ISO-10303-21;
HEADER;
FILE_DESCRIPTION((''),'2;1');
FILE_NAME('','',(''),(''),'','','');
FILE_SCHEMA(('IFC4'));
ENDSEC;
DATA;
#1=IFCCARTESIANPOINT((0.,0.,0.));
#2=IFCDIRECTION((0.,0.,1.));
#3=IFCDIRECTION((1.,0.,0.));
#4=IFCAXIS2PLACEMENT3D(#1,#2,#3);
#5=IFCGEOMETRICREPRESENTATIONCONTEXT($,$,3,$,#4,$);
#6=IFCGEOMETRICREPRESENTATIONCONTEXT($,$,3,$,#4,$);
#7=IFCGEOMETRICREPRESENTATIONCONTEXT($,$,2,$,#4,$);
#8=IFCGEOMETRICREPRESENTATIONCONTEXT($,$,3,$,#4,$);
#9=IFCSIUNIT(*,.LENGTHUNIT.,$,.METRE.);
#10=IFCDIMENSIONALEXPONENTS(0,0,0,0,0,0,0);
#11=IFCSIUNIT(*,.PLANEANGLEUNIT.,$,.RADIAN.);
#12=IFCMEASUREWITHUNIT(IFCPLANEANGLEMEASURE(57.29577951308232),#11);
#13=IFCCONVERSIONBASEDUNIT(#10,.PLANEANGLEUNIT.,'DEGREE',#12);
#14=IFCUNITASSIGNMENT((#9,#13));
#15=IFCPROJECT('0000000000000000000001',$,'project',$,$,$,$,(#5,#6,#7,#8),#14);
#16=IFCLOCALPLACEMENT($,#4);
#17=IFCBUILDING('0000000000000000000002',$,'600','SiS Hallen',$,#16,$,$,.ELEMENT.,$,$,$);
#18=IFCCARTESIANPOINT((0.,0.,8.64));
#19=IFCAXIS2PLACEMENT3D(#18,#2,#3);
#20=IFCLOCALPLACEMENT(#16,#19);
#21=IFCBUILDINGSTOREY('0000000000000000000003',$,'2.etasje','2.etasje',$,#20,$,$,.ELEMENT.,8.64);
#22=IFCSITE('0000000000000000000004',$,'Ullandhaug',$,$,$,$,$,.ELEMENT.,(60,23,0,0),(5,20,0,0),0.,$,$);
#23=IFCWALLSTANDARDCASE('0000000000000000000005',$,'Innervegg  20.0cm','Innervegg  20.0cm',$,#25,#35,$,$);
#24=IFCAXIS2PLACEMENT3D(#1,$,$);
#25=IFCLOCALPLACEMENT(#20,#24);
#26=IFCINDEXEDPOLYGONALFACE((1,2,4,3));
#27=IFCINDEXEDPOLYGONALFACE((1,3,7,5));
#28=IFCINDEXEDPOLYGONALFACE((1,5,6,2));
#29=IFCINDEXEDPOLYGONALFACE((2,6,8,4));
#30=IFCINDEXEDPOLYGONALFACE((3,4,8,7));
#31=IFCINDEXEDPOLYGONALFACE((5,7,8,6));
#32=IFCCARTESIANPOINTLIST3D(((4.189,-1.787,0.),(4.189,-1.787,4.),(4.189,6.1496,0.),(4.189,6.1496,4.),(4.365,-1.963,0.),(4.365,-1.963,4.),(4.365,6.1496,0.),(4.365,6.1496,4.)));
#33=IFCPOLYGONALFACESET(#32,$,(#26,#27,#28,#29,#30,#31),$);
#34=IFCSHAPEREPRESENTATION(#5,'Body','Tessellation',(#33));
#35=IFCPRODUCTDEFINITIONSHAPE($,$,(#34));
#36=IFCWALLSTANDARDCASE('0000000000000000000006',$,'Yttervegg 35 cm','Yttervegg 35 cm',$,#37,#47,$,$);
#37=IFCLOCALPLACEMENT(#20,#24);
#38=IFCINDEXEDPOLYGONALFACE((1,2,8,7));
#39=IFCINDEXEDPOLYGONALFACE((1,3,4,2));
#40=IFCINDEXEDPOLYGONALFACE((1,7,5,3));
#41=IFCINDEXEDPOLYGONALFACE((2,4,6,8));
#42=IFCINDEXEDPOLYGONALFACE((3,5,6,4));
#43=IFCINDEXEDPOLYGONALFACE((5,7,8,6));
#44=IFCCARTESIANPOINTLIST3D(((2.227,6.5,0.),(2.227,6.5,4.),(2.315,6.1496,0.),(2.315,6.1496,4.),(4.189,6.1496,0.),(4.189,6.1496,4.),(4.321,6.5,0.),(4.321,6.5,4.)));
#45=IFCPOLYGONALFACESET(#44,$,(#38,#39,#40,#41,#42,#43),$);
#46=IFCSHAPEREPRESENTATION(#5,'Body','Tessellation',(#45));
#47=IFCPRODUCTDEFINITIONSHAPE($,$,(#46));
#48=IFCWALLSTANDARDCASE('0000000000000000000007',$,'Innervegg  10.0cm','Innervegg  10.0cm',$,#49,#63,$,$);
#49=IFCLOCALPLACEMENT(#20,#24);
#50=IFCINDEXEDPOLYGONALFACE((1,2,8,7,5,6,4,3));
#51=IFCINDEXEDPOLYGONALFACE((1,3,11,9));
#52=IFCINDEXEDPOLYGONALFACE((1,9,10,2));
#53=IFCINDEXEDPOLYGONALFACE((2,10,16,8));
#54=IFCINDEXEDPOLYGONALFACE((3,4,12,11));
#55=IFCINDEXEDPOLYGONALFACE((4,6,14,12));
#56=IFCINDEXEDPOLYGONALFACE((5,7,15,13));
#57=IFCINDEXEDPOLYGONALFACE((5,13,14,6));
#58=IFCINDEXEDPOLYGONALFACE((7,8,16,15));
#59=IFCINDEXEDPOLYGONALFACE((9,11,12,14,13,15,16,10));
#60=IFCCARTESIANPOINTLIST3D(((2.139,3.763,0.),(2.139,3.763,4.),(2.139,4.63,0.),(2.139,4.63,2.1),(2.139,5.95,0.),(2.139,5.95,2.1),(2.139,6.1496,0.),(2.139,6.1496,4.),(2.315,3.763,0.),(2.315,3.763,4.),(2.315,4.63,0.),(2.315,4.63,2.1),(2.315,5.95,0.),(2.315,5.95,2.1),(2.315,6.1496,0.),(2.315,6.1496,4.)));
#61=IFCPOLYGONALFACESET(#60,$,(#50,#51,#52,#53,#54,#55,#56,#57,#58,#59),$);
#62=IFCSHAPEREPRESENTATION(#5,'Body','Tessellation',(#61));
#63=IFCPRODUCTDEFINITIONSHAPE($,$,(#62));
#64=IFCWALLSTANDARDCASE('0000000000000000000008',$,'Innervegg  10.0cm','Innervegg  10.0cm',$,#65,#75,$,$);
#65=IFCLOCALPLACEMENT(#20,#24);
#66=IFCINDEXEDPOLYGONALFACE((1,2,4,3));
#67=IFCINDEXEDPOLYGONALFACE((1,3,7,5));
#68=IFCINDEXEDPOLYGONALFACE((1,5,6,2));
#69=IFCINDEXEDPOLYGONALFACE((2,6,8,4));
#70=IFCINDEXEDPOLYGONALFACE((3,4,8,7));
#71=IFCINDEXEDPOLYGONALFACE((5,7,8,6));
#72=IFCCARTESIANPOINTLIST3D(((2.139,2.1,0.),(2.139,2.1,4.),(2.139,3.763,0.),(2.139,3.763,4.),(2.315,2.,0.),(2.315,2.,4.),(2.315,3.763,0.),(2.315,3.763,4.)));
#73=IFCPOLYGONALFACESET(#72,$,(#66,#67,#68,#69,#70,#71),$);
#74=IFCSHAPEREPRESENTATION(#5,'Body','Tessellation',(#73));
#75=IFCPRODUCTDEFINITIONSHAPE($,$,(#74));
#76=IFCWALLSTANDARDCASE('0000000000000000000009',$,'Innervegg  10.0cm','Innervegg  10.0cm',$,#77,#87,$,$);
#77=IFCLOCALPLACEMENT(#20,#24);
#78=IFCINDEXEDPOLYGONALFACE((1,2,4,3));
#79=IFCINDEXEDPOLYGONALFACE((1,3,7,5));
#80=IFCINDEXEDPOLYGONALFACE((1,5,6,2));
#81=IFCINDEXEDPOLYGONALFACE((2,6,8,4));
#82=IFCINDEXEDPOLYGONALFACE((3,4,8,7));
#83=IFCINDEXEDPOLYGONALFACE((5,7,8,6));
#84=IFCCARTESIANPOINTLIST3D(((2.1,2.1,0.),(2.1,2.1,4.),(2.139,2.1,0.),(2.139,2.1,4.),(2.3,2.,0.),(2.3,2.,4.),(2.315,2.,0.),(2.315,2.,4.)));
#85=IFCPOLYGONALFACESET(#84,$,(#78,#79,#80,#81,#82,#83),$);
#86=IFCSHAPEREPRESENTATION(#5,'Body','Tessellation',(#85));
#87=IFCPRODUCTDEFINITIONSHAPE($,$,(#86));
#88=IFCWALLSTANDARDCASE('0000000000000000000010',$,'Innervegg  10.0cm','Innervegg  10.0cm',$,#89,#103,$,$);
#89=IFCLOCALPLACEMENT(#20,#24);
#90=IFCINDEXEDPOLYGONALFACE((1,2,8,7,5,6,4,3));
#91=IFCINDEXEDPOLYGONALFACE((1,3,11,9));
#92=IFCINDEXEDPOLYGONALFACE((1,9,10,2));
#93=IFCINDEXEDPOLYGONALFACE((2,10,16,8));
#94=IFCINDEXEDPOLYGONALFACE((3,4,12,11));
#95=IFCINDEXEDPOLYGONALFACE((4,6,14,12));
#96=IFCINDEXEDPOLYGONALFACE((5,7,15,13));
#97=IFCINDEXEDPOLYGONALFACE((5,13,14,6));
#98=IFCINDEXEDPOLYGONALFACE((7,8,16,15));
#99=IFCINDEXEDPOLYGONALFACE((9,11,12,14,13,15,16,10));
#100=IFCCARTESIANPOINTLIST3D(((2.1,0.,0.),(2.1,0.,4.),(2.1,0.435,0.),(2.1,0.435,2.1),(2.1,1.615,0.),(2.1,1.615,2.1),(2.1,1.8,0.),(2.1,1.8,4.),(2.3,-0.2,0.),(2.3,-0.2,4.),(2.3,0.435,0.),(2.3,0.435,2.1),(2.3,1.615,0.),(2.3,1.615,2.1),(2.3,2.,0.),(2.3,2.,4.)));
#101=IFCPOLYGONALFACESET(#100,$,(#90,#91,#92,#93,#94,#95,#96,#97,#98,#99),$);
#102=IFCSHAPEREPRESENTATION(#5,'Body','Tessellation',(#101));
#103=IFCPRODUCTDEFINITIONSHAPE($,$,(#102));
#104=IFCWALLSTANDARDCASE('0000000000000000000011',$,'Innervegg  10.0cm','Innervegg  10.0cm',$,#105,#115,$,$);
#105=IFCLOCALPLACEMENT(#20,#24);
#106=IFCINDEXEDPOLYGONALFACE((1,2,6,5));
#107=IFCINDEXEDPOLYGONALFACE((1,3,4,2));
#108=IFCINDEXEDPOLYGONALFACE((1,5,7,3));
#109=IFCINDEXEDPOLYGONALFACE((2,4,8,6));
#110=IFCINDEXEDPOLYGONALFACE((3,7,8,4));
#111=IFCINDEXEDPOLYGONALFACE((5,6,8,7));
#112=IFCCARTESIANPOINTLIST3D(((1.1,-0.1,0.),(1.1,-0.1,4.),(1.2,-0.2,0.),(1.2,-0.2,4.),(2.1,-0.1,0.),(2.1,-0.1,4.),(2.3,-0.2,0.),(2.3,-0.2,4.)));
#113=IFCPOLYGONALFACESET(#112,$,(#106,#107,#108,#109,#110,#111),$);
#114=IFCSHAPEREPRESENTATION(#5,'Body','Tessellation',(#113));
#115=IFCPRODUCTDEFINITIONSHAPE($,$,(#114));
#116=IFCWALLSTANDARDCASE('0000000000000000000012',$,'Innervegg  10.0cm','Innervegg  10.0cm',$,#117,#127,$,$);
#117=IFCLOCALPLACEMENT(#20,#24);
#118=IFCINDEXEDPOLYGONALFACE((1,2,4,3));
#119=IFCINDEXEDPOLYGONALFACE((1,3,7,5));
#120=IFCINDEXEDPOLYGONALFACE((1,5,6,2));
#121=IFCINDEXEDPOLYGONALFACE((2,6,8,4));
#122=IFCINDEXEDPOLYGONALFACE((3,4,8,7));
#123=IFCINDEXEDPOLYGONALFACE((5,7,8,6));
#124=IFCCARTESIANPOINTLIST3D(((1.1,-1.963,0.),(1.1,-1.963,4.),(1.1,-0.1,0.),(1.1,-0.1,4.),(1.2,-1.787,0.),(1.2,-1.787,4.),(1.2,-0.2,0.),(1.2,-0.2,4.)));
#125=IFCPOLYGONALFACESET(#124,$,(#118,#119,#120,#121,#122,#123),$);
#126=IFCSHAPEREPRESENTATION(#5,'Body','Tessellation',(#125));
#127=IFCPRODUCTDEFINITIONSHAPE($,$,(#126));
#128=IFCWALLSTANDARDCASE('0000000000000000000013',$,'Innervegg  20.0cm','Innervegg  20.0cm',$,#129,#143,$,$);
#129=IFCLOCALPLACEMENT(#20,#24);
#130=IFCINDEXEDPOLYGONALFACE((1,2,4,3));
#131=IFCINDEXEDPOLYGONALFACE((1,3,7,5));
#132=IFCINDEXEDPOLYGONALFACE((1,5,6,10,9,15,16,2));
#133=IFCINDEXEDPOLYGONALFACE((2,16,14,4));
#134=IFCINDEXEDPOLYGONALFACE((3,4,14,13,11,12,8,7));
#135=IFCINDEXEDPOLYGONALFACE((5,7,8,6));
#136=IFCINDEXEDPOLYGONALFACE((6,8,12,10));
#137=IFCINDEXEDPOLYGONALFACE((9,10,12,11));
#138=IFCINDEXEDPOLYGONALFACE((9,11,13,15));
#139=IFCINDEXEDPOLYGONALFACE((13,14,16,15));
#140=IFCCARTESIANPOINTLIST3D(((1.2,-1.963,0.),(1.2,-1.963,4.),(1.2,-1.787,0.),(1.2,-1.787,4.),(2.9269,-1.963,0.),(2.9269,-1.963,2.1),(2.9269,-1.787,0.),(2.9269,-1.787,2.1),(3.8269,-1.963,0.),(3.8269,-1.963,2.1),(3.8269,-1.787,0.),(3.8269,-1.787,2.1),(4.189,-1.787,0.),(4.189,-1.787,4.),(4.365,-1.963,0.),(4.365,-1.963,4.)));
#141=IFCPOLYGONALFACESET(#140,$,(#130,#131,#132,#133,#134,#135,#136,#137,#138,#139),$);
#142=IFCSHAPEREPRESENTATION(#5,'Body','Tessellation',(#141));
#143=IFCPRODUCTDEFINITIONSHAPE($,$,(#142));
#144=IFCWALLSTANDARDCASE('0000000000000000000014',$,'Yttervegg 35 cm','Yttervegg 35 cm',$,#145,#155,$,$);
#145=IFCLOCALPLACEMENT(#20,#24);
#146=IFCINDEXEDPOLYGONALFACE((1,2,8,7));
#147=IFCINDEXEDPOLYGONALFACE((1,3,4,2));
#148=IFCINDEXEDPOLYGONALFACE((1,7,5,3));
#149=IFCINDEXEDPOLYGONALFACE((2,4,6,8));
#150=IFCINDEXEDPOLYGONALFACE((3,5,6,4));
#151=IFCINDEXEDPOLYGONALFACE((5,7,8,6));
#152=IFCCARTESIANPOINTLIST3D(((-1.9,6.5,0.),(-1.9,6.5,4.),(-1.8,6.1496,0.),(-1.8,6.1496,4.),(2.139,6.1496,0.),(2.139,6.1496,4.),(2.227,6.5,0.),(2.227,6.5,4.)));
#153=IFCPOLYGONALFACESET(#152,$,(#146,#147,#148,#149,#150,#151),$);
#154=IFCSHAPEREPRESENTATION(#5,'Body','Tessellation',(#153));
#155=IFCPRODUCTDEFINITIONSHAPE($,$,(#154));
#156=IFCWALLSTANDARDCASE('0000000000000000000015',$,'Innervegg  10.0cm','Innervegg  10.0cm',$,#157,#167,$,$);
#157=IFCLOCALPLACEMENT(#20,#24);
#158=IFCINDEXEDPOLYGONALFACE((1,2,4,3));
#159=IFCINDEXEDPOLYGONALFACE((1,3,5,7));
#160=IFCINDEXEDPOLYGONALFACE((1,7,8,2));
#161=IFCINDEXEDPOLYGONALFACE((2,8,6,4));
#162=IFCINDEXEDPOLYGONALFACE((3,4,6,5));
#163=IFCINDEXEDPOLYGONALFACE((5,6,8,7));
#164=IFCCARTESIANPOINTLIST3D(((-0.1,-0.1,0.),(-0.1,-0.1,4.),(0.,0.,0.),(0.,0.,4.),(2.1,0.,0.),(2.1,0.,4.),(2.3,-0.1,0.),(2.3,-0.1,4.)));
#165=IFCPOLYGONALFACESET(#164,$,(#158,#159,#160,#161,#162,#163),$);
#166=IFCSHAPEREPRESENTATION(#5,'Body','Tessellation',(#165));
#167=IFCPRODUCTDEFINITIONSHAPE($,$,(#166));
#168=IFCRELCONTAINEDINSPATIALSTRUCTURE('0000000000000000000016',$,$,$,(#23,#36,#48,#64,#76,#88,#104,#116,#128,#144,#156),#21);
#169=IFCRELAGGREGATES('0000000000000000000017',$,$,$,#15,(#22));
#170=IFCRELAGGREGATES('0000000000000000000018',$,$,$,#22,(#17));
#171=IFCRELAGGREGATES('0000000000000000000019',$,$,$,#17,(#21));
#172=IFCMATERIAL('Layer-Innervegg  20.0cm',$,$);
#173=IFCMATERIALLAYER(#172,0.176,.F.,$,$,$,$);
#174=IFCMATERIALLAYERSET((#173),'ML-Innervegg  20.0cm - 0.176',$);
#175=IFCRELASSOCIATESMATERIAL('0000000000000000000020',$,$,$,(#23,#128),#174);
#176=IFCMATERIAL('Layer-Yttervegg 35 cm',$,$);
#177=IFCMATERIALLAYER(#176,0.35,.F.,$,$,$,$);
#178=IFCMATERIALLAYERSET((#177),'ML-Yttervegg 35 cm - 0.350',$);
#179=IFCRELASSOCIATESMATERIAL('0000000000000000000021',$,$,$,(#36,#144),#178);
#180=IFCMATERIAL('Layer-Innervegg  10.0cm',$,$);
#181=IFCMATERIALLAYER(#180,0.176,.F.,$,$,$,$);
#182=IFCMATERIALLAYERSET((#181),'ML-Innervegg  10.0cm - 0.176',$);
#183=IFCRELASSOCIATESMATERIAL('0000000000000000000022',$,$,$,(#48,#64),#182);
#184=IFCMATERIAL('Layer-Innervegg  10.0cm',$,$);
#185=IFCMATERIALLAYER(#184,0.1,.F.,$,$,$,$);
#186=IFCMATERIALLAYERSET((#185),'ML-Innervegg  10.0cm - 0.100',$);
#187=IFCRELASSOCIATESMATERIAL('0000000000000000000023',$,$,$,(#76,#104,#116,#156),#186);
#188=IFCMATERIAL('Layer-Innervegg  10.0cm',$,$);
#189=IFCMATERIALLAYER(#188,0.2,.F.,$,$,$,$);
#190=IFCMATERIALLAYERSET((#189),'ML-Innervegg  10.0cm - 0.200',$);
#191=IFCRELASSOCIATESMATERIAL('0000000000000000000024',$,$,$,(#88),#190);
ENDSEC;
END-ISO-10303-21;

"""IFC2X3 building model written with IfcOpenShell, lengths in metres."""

from ifc_helpers import new_model, entity, si_unit, converted_unit, frame, origin_with_axes, place, context, project, spatial, polyline, outline, extrude, material, layer, layer_set, layer_usage, element, save


model = new_model("IFC2X3")

# Units and contexts
context_of_model_1 = context(None, 3, world=origin_with_axes())
context_of_model_2 = context(None, 3, world=origin_with_axes())
context_of_model_3 = context(None, 2, world=origin_with_axes())
context_of_model_4 = context(None, 3, world=origin_with_axes())
ifc_project = project(units=[si_unit("LENGTHUNIT", "METRE"), converted_unit("PLANEANGLEUNIT", "DEGREE", entity("IfcPlaneAngleMeasure", 57.29577951308232), si_unit("PLANEANGLEUNIT", "RADIAN"), dimensions=[0, 0, 0, 0, 0, 0, 0])], contexts=[context_of_model_1, context_of_model_2, context_of_model_3, context_of_model_4])

# Site, building, storey
site = spatial("IfcSite", under=ifc_project, Name="Ullandhaug", CompositionType="ELEMENT", RefLatitude=(60, 23, 0, 0), RefLongitude=(5, 20, 0, 0), RefElevation=0.0)
building_placement = place(None, origin_with_axes())
building = spatial("IfcBuilding", under=site, at=building_placement, Name="600", Description="SiS Hallen", CompositionType="ELEMENT")
storey_placement = place(building_placement, frame((0.0, 0.0, 8.64), z_axis=(0.0, 0.0, 1.0), x_axis=(1.0, 0.0, 0.0)))
storey = spatial("IfcBuildingStorey", under=building, at=storey_placement, Name="2.etasje", Description="2.etasje", CompositionType="ELEMENT", Elevation=8.64)

# Walls
ifc_material_1 = material(Name="Layer-Yttervegg 35 cm")
ifc_layer_1 = layer(ifc_material_1, 0.35, ventilated=False)
ifc_layer_set_1 = layer_set([ifc_layer_1], Name="ML-Yttervegg 35 cm - 0.350")
ifc_layer_usage_1 = layer_usage(ifc_layer_set_1, "AXIS2", "POSITIVE", 0.0)
ifc_material_2 = material(Name="Layer-Innervegg  20.0cm")
ifc_layer_2 = layer(ifc_material_2, 0.176, ventilated=False)
ifc_layer_set_2 = layer_set([ifc_layer_2], Name="ML-Innervegg  20.0cm - 0.176")
ifc_layer_usage_2 = layer_usage(ifc_layer_set_2, "AXIS2", "POSITIVE", 0.0)
wall_1_placement = place(storey_placement, frame((4.365, -1.963, 0.0), z_axis=(0.0, 0.0, 1.0), x_axis=(0.0, 1.0, 0.0)))
element("IfcWallStandardCase", 1, at=wall_1_placement, inside=storey, material=ifc_layer_usage_2, Name="Innervegg  20.0cm", Description="Innervegg  20.0cm", context=context_of_model_1, shape_type="SweptSolid", body=[
    extrude(outline(polyline([(0.0, 0.0), (8.1126, 0.0), (8.1126, 0.176), (0.176, 0.176), (0.0, 0.0)])), frame((0.0, 0.0, 0.0), z_axis=(0.0, 0.0, 1.0), x_axis=(1.0, 0.0, 0.0)), (0.0, 0.0, 1.0), 4.0),
])
wall_2_placement = place(storey_placement, frame((4.321, 6.5, 0.0), z_axis=(0.0, 0.0, 1.0), x_axis=(-1.0, 0.0, 0.0)))
element("IfcWallStandardCase", 2, at=wall_2_placement, inside=storey, material=ifc_layer_usage_1, Name="Yttervegg 35 cm", Description="Yttervegg 35 cm", context=context_of_model_1, shape_type="SweptSolid", body=[
    extrude(outline(polyline([(0.0, 0.0), (2.094, 0.0), (2.006, 0.3504), (0.132, 0.3504), (0.0, 0.0)])), frame((0.0, 0.0, 0.0), z_axis=(0.0, 0.0, 1.0), x_axis=(1.0, 0.0, 0.0)), (0.0, 0.0, 1.0), 4.0),
])

# Wall, opening
ifc_material_3 = material(Name="Layer-Innervegg  10.0cm")
ifc_layer_3 = layer(ifc_material_3, 0.176, ventilated=False)
ifc_layer_set_3 = layer_set([ifc_layer_3], Name="ML-Innervegg  10.0cm - 0.176")
ifc_layer_usage_3 = layer_usage(ifc_layer_set_3, "AXIS2", "POSITIVE", 0.0)
wall_3_placement = place(storey_placement, frame((2.139, 6.1496, 0.0), z_axis=(0.0, 0.0, 1.0), x_axis=(0.0, -1.0, 0.0)))
wall_3 = element("IfcWallStandardCase", 3, at=wall_3_placement, inside=storey, material=ifc_layer_usage_3, Name="Innervegg  10.0cm", Description="Innervegg  10.0cm", context=context_of_model_1, shape_type="SweptSolid", body=[
    extrude(outline(polyline([(0.0, 0.0), (2.3866, 0.0), (2.3866, 0.176), (0.0, 0.176), (0.0, 0.0)])), frame((0.0, 0.0, 0.0), z_axis=(0.0, 0.0, 1.0), x_axis=(1.0, 0.0, 0.0)), (0.0, 0.0, 1.0), 4.0),
])
opening_1_placement = place(wall_3_placement, frame((0.1996, 0.176, 0.0), z_axis=(0.0, 0.0, 1.0), x_axis=(1.0, 0.0, 0.0)))
element("IfcOpeningElement", 4, at=opening_1_placement, cuts=wall_3, context=context_of_model_1, shape_type="SweptSolid", body=[
    extrude(outline(polyline([(0.0, 0.0), (2.1, 0.0), (2.1, 1.32), (0.0, 1.32), (0.0, 0.0)])), frame((0.0, 0.0, 0.0), z_axis=(0.0, 1.0, 0.0), x_axis=(0.0, 0.0, 1.0)), (0.0, 0.0, -1.0), 0.176),
])

# Walls
wall_4_placement = place(storey_placement, frame((2.139, 3.763, 0.0), z_axis=(0.0, 0.0, 1.0), x_axis=(0.0, -1.0, 0.0)))
element("IfcWallStandardCase", 5, at=wall_4_placement, inside=storey, material=ifc_layer_usage_3, Name="Innervegg  10.0cm", Description="Innervegg  10.0cm", context=context_of_model_1, shape_type="SweptSolid", body=[
    extrude(outline(polyline([(0.0, 0.0), (1.663, 0.0), (1.763, 0.176), (0.0, 0.176), (0.0, 0.0)])), frame((0.0, 0.0, 0.0), z_axis=(0.0, 0.0, 1.0), x_axis=(1.0, 0.0, 0.0)), (0.0, 0.0, 1.0), 4.0),
])
ifc_material_4 = material(Name="Layer-Innervegg  10.0cm")
ifc_layer_4 = layer(ifc_material_4, 0.1, ventilated=False)
ifc_layer_set_4 = layer_set([ifc_layer_4], Name="ML-Innervegg  10.0cm - 0.100")
ifc_layer_usage_4 = layer_usage(ifc_layer_set_4, "AXIS2", "POSITIVE", 0.0)
wall_5_placement = place(storey_placement, frame((2.139, 2.1, 0.0), z_axis=(0.0, 0.0, 1.0), x_axis=(-1.0, 0.0, 0.0)))
element("IfcWallStandardCase", 6, at=wall_5_placement, inside=storey, material=ifc_layer_usage_4, Name="Innervegg  10.0cm", Description="Innervegg  10.0cm", context=context_of_model_1, shape_type="SweptSolid", body=[
    extrude(outline(polyline([(0.0, 0.0), (0.039, 0.0), (-0.161, 0.1), (-0.176, 0.1), (0.0, 0.0)])), frame((0.0, 0.0, 0.0), z_axis=(0.0, 0.0, 1.0), x_axis=(1.0, 0.0, 0.0)), (0.0, 0.0, 1.0), 4.0),
])

# Wall, opening
ifc_material_5 = material(Name="Layer-Innervegg  10.0cm")
ifc_layer_5 = layer(ifc_material_5, 0.2, ventilated=False)
ifc_layer_set_5 = layer_set([ifc_layer_5], Name="ML-Innervegg  10.0cm - 0.200")
ifc_layer_usage_5 = layer_usage(ifc_layer_set_5, "AXIS2", "POSITIVE", 0.0)
wall_6_placement = place(storey_placement, frame((2.1, 1.8, 0.0), z_axis=(0.0, 0.0, 1.0), x_axis=(0.0, -1.0, 0.0)))
wall_6 = element("IfcWallStandardCase", 7, at=wall_6_placement, inside=storey, material=ifc_layer_usage_5, Name="Innervegg  10.0cm", Description="Innervegg  10.0cm", context=context_of_model_1, shape_type="SweptSolid", body=[
    extrude(outline(polyline([(0.0, 0.0), (1.8, 0.0), (2.0, 0.2), (-0.2, 0.2), (0.0, 0.0)])), frame((0.0, 0.0, 0.0), z_axis=(0.0, 0.0, 1.0), x_axis=(1.0, 0.0, 0.0)), (0.0, 0.0, 1.0), 4.0),
])
opening_2_placement = place(wall_6_placement, frame((0.185, 0.2, 0.0), z_axis=(0.0, 0.0, 1.0), x_axis=(1.0, 0.0, 0.0)))
element("IfcOpeningElement", 8, at=opening_2_placement, cuts=wall_6, context=context_of_model_1, shape_type="SweptSolid", body=[
    extrude(outline(polyline([(0.0, 0.0), (2.1, 0.0), (2.1, 1.18), (0.0, 1.18), (0.0, 0.0)])), frame((0.0, 0.0, 0.0), z_axis=(0.0, 1.0, 0.0), x_axis=(0.0, 0.0, 1.0)), (0.0, 0.0, -1.0), 0.2),
])

# Walls
wall_7_placement = place(storey_placement, frame((2.1, -0.1, 0.0), z_axis=(0.0, 0.0, 1.0), x_axis=(-1.0, 0.0, 0.0)))
element("IfcWallStandardCase", 9, at=wall_7_placement, inside=storey, material=ifc_layer_usage_4, Name="Innervegg  10.0cm", Description="Innervegg  10.0cm", context=context_of_model_1, shape_type="SweptSolid", body=[
    extrude(outline(polyline([(0.0, 0.0), (1.0, 0.0), (0.9, 0.1), (-0.2, 0.1), (0.0, 0.0)])), frame((0.0, 0.0, 0.0), z_axis=(0.0, 0.0, 1.0), x_axis=(1.0, 0.0, 0.0)), (0.0, 0.0, 1.0), 4.0),
])
wall_8_placement = place(storey_placement, frame((1.1, -0.1, 0.0), z_axis=(0.0, 0.0, 1.0), x_axis=(0.0, -1.0, 0.0)))
element("IfcWallStandardCase", 10, at=wall_8_placement, inside=storey, material=ifc_layer_usage_4, Name="Innervegg  10.0cm", Description="Innervegg  10.0cm", context=context_of_model_1, shape_type="SweptSolid", body=[
    extrude(outline(polyline([(0.0, 0.0), (1.863, 0.0), (1.687, 0.1), (0.1, 0.1), (0.0, 0.0)])), frame((0.0, 0.0, 0.0), z_axis=(0.0, 0.0, 1.0), x_axis=(1.0, 0.0, 0.0)), (0.0, 0.0, 1.0), 4.0),
])

# Wall, opening
wall_9_placement = place(storey_placement, frame((1.2, -1.963, 0.0), z_axis=(0.0, 0.0, 1.0), x_axis=(1.0, 0.0, 0.0)))
wall_9 = element("IfcWallStandardCase", 11, at=wall_9_placement, inside=storey, material=ifc_layer_usage_2, Name="Innervegg  20.0cm", Description="Innervegg  20.0cm", context=context_of_model_1, shape_type="SweptSolid", body=[
    extrude(outline(polyline([(0.0, 0.0), (3.165, 0.0), (2.989, 0.176), (0.0, 0.176), (0.0, 0.0)])), origin_with_axes(), (0.0, 0.0, 1.0), 4.0),
])
opening_3_placement = place(wall_9_placement, frame((1.7269, 0.176, 0.0), z_axis=(0.0, 0.0, 1.0), x_axis=(1.0, 0.0, 0.0)))
element("IfcOpeningElement", 12, at=opening_3_placement, cuts=wall_9, context=context_of_model_1, shape_type="SweptSolid", body=[
    extrude(outline(polyline([(0.0, 0.0), (2.1, 0.0), (2.1, 0.9), (0.0, 0.9), (0.0, 0.0)])), frame((0.0, 0.0, 0.0), z_axis=(0.0, 1.0, 0.0), x_axis=(0.0, 0.0, 1.0)), (0.0, 0.0, -1.0), 0.176),
])

# Walls
wall_10_placement = place(storey_placement, frame((2.227, 6.5, 0.0), z_axis=(0.0, 0.0, 1.0), x_axis=(-1.0, 0.0, 0.0)))
element("IfcWallStandardCase", 13, at=wall_10_placement, inside=storey, material=ifc_layer_usage_1, Name="Yttervegg 35 cm", Description="Yttervegg 35 cm", context=context_of_model_1, shape_type="SweptSolid", body=[
    extrude(outline(polyline([(0.0, 0.0), (4.127, 0.0), (4.027, 0.3504), (0.088, 0.3504), (0.0, 0.0)])), frame((0.0, 0.0, 0.0), z_axis=(0.0, 0.0, 1.0), x_axis=(1.0, 0.0, 0.0)), (0.0, 0.0, 1.0), 4.0),
])
wall_11_placement = place(storey_placement, frame((-0.1, -0.1, 0.0), z_axis=(0.0, 0.0, 1.0), x_axis=(1.0, 0.0, 0.0)))
element("IfcWallStandardCase", 14, at=wall_11_placement, inside=storey, material=ifc_layer_usage_4, Name="Innervegg  10.0cm", Description="Innervegg  10.0cm", context=context_of_model_1, shape_type="SweptSolid", body=[
    extrude(outline(polyline([(0.0, 0.0), (2.4, 0.0), (2.2, 0.1), (0.1, 0.1), (0.0, 0.0)])), frame((0.0, 0.0, 0.0), z_axis=(0.0, 0.0, 1.0), x_axis=(1.0, 0.0, 0.0)), (0.0, 0.0, 1.0), 4.0),
])

save(model, "model.ifc")
